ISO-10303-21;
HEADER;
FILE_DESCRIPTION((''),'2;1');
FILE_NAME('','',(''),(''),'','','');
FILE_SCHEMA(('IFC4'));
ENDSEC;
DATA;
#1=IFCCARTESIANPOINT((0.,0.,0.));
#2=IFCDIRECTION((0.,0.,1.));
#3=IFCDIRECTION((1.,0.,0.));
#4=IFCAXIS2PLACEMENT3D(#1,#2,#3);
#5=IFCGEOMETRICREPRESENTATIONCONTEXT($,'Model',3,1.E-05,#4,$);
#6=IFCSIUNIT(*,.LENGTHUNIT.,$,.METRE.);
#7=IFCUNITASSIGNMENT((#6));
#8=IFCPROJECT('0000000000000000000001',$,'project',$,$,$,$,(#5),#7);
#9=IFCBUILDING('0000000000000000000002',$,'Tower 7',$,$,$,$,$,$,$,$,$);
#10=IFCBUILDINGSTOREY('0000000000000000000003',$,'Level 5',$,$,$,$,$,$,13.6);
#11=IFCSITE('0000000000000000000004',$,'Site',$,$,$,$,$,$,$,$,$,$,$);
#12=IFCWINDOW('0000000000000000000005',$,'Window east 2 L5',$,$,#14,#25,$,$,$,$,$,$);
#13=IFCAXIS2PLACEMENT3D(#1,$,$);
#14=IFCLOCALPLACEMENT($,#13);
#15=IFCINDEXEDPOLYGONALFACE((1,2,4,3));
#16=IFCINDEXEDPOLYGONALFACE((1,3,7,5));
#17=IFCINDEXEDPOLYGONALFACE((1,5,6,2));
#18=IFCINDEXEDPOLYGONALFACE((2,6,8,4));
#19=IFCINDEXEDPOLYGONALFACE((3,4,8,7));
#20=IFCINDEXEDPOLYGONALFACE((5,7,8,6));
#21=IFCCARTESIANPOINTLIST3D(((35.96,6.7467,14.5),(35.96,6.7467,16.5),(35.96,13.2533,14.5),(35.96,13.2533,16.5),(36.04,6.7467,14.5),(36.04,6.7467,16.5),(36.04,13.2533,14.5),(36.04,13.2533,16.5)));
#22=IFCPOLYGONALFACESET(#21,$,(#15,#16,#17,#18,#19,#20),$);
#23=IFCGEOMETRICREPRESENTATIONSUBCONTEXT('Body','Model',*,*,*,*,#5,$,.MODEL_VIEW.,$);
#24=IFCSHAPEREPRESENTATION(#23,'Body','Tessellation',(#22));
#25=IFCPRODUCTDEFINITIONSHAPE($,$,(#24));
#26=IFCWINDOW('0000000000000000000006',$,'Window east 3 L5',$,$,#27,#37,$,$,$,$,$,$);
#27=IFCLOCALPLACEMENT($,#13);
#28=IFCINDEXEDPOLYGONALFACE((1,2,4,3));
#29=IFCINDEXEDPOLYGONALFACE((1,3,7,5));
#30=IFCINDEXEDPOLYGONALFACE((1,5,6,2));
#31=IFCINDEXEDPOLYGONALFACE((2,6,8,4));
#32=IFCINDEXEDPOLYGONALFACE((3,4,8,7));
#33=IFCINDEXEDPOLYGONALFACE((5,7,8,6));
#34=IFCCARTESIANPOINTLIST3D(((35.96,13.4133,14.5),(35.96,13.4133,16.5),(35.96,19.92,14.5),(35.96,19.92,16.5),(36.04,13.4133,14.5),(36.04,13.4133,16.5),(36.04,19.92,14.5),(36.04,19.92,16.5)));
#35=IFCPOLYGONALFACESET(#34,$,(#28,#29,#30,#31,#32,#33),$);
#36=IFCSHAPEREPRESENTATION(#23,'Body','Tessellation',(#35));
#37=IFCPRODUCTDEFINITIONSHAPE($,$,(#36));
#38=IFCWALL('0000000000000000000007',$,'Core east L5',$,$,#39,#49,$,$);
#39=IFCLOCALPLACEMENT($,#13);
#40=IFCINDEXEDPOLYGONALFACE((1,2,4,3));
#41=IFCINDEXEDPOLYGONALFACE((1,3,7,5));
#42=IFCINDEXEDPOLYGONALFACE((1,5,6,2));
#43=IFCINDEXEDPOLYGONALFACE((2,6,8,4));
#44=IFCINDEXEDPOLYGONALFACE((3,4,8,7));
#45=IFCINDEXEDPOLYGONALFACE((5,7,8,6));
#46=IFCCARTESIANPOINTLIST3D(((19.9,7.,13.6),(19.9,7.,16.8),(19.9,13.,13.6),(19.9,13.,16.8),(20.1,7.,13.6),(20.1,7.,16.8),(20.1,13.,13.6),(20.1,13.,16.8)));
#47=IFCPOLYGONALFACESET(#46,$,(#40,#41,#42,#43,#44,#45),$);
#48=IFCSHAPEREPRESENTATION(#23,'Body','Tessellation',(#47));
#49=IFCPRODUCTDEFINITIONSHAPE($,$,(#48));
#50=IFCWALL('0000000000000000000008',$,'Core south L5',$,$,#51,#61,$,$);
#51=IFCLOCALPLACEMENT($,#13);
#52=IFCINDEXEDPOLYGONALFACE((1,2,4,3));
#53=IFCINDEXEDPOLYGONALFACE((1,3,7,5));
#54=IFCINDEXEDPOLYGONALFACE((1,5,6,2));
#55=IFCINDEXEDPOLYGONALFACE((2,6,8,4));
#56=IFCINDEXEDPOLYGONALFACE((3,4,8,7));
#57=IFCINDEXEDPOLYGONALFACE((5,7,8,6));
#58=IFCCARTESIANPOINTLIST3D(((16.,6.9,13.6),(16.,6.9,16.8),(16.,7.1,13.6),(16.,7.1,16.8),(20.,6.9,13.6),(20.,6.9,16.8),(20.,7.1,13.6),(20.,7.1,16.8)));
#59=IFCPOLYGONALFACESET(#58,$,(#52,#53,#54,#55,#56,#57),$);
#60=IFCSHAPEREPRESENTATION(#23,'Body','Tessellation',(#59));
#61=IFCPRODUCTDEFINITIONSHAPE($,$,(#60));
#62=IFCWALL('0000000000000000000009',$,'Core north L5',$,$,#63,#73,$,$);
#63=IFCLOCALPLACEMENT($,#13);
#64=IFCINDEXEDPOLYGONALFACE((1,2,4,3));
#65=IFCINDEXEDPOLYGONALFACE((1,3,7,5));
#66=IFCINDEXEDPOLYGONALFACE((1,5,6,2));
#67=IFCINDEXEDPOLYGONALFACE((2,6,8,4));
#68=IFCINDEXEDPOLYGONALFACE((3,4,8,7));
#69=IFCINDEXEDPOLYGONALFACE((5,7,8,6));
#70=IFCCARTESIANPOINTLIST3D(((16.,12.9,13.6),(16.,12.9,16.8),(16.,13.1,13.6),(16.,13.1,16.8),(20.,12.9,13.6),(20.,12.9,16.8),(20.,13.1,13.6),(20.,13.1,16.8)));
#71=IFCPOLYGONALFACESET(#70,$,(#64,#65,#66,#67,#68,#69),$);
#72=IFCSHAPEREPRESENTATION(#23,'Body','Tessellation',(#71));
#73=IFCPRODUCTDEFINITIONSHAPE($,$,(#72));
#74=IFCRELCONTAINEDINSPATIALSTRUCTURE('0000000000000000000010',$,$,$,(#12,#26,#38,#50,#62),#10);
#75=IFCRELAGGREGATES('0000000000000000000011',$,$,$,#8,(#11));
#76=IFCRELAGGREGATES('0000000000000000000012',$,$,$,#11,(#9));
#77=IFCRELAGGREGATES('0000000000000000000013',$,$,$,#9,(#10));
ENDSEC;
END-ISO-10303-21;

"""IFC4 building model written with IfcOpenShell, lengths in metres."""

from ifc_helpers import new_model, si_unit, frame, origin, origin_with_axes, origin_2d, place, context, subcontext, project, spatial, rectangle, extrude, element, save


model = new_model("IFC4")

# Units and contexts
model_context = context("Model", 3, precision=1e-05, world=origin_with_axes())
body_context = subcontext(model_context, "Body", "Model", "MODEL_VIEW")
ifc_project = project(units=[si_unit("LENGTHUNIT", "METRE")], contexts=[model_context])

# Site, building, storey
site = spatial("IfcSite", under=ifc_project, Name="Site")
building = spatial("IfcBuilding", under=site, Name="Tower 7")
storey = spatial("IfcBuildingStorey", under=building, Name="Level 5", Elevation=13.6)

# Windows
for number, where, z_axis, x_axis, name in (
    (1, (36.0, 10.0, 14.5), (0.0, 0.0, 1.0), (1.0, 0.0, 0.0), "Window east 2 L5"),
):
    element("IfcWindow", number, at=place(None, frame(where, z_axis=z_axis, x_axis=x_axis)), inside=storey, Name=name, context=body_context, shape_type="SweptSolid", body=[
        extrude(rectangle(XDim=0.08, YDim=6.5067, at=origin_2d()), origin(), (0.0, 0.0, 1.0), 2.0),
    ])
window_placement = place(None, frame((36.0, 16.6667, 14.5), z_axis=(0.0, 0.0, 1.0), x_axis=(1.0, 0.0, 0.0)))
element("IfcWindow", 2, at=window_placement, inside=storey, Name="Window east 3 L5", context=body_context, shape_type="SweptSolid", body=[
    extrude(rectangle(XDim=0.08, YDim=6.5067, at=origin_2d()), origin(), (0.0, 0.0, 1.0), 2.0),
])

# Walls
wall_1_placement = place(None, frame((20.0, 10.0, 13.6), z_axis=(0.0, 0.0, 1.0), x_axis=(1.0, 0.0, 0.0)))
element("IfcWall", 3, at=wall_1_placement, inside=storey, Name="Core east L5", context=body_context, shape_type="SweptSolid", body=[
    extrude(rectangle(XDim=0.2, YDim=6.0, at=origin_2d()), origin(), (0.0, 0.0, 1.0), 3.2),
])
for number, where, z_axis, x_axis, name in (
    (4, (18.0, 7.0, 13.6), (0.0, 0.0, 1.0), (1.0, 0.0, 0.0), "Core south L5"),
    (5, (18.0, 13.0, 13.6), (0.0, 0.0, 1.0), (1.0, 0.0, 0.0), "Core north L5"),
):
    element("IfcWall", number, at=place(None, frame(where, z_axis=z_axis, x_axis=x_axis)), inside=storey, Name=name, context=body_context, shape_type="SweptSolid", body=[
        extrude(rectangle(XDim=4.0, YDim=0.2, at=origin_2d()), origin(), (0.0, 0.0, 1.0), 3.2),
    ])

save(model, "model.ifc")
